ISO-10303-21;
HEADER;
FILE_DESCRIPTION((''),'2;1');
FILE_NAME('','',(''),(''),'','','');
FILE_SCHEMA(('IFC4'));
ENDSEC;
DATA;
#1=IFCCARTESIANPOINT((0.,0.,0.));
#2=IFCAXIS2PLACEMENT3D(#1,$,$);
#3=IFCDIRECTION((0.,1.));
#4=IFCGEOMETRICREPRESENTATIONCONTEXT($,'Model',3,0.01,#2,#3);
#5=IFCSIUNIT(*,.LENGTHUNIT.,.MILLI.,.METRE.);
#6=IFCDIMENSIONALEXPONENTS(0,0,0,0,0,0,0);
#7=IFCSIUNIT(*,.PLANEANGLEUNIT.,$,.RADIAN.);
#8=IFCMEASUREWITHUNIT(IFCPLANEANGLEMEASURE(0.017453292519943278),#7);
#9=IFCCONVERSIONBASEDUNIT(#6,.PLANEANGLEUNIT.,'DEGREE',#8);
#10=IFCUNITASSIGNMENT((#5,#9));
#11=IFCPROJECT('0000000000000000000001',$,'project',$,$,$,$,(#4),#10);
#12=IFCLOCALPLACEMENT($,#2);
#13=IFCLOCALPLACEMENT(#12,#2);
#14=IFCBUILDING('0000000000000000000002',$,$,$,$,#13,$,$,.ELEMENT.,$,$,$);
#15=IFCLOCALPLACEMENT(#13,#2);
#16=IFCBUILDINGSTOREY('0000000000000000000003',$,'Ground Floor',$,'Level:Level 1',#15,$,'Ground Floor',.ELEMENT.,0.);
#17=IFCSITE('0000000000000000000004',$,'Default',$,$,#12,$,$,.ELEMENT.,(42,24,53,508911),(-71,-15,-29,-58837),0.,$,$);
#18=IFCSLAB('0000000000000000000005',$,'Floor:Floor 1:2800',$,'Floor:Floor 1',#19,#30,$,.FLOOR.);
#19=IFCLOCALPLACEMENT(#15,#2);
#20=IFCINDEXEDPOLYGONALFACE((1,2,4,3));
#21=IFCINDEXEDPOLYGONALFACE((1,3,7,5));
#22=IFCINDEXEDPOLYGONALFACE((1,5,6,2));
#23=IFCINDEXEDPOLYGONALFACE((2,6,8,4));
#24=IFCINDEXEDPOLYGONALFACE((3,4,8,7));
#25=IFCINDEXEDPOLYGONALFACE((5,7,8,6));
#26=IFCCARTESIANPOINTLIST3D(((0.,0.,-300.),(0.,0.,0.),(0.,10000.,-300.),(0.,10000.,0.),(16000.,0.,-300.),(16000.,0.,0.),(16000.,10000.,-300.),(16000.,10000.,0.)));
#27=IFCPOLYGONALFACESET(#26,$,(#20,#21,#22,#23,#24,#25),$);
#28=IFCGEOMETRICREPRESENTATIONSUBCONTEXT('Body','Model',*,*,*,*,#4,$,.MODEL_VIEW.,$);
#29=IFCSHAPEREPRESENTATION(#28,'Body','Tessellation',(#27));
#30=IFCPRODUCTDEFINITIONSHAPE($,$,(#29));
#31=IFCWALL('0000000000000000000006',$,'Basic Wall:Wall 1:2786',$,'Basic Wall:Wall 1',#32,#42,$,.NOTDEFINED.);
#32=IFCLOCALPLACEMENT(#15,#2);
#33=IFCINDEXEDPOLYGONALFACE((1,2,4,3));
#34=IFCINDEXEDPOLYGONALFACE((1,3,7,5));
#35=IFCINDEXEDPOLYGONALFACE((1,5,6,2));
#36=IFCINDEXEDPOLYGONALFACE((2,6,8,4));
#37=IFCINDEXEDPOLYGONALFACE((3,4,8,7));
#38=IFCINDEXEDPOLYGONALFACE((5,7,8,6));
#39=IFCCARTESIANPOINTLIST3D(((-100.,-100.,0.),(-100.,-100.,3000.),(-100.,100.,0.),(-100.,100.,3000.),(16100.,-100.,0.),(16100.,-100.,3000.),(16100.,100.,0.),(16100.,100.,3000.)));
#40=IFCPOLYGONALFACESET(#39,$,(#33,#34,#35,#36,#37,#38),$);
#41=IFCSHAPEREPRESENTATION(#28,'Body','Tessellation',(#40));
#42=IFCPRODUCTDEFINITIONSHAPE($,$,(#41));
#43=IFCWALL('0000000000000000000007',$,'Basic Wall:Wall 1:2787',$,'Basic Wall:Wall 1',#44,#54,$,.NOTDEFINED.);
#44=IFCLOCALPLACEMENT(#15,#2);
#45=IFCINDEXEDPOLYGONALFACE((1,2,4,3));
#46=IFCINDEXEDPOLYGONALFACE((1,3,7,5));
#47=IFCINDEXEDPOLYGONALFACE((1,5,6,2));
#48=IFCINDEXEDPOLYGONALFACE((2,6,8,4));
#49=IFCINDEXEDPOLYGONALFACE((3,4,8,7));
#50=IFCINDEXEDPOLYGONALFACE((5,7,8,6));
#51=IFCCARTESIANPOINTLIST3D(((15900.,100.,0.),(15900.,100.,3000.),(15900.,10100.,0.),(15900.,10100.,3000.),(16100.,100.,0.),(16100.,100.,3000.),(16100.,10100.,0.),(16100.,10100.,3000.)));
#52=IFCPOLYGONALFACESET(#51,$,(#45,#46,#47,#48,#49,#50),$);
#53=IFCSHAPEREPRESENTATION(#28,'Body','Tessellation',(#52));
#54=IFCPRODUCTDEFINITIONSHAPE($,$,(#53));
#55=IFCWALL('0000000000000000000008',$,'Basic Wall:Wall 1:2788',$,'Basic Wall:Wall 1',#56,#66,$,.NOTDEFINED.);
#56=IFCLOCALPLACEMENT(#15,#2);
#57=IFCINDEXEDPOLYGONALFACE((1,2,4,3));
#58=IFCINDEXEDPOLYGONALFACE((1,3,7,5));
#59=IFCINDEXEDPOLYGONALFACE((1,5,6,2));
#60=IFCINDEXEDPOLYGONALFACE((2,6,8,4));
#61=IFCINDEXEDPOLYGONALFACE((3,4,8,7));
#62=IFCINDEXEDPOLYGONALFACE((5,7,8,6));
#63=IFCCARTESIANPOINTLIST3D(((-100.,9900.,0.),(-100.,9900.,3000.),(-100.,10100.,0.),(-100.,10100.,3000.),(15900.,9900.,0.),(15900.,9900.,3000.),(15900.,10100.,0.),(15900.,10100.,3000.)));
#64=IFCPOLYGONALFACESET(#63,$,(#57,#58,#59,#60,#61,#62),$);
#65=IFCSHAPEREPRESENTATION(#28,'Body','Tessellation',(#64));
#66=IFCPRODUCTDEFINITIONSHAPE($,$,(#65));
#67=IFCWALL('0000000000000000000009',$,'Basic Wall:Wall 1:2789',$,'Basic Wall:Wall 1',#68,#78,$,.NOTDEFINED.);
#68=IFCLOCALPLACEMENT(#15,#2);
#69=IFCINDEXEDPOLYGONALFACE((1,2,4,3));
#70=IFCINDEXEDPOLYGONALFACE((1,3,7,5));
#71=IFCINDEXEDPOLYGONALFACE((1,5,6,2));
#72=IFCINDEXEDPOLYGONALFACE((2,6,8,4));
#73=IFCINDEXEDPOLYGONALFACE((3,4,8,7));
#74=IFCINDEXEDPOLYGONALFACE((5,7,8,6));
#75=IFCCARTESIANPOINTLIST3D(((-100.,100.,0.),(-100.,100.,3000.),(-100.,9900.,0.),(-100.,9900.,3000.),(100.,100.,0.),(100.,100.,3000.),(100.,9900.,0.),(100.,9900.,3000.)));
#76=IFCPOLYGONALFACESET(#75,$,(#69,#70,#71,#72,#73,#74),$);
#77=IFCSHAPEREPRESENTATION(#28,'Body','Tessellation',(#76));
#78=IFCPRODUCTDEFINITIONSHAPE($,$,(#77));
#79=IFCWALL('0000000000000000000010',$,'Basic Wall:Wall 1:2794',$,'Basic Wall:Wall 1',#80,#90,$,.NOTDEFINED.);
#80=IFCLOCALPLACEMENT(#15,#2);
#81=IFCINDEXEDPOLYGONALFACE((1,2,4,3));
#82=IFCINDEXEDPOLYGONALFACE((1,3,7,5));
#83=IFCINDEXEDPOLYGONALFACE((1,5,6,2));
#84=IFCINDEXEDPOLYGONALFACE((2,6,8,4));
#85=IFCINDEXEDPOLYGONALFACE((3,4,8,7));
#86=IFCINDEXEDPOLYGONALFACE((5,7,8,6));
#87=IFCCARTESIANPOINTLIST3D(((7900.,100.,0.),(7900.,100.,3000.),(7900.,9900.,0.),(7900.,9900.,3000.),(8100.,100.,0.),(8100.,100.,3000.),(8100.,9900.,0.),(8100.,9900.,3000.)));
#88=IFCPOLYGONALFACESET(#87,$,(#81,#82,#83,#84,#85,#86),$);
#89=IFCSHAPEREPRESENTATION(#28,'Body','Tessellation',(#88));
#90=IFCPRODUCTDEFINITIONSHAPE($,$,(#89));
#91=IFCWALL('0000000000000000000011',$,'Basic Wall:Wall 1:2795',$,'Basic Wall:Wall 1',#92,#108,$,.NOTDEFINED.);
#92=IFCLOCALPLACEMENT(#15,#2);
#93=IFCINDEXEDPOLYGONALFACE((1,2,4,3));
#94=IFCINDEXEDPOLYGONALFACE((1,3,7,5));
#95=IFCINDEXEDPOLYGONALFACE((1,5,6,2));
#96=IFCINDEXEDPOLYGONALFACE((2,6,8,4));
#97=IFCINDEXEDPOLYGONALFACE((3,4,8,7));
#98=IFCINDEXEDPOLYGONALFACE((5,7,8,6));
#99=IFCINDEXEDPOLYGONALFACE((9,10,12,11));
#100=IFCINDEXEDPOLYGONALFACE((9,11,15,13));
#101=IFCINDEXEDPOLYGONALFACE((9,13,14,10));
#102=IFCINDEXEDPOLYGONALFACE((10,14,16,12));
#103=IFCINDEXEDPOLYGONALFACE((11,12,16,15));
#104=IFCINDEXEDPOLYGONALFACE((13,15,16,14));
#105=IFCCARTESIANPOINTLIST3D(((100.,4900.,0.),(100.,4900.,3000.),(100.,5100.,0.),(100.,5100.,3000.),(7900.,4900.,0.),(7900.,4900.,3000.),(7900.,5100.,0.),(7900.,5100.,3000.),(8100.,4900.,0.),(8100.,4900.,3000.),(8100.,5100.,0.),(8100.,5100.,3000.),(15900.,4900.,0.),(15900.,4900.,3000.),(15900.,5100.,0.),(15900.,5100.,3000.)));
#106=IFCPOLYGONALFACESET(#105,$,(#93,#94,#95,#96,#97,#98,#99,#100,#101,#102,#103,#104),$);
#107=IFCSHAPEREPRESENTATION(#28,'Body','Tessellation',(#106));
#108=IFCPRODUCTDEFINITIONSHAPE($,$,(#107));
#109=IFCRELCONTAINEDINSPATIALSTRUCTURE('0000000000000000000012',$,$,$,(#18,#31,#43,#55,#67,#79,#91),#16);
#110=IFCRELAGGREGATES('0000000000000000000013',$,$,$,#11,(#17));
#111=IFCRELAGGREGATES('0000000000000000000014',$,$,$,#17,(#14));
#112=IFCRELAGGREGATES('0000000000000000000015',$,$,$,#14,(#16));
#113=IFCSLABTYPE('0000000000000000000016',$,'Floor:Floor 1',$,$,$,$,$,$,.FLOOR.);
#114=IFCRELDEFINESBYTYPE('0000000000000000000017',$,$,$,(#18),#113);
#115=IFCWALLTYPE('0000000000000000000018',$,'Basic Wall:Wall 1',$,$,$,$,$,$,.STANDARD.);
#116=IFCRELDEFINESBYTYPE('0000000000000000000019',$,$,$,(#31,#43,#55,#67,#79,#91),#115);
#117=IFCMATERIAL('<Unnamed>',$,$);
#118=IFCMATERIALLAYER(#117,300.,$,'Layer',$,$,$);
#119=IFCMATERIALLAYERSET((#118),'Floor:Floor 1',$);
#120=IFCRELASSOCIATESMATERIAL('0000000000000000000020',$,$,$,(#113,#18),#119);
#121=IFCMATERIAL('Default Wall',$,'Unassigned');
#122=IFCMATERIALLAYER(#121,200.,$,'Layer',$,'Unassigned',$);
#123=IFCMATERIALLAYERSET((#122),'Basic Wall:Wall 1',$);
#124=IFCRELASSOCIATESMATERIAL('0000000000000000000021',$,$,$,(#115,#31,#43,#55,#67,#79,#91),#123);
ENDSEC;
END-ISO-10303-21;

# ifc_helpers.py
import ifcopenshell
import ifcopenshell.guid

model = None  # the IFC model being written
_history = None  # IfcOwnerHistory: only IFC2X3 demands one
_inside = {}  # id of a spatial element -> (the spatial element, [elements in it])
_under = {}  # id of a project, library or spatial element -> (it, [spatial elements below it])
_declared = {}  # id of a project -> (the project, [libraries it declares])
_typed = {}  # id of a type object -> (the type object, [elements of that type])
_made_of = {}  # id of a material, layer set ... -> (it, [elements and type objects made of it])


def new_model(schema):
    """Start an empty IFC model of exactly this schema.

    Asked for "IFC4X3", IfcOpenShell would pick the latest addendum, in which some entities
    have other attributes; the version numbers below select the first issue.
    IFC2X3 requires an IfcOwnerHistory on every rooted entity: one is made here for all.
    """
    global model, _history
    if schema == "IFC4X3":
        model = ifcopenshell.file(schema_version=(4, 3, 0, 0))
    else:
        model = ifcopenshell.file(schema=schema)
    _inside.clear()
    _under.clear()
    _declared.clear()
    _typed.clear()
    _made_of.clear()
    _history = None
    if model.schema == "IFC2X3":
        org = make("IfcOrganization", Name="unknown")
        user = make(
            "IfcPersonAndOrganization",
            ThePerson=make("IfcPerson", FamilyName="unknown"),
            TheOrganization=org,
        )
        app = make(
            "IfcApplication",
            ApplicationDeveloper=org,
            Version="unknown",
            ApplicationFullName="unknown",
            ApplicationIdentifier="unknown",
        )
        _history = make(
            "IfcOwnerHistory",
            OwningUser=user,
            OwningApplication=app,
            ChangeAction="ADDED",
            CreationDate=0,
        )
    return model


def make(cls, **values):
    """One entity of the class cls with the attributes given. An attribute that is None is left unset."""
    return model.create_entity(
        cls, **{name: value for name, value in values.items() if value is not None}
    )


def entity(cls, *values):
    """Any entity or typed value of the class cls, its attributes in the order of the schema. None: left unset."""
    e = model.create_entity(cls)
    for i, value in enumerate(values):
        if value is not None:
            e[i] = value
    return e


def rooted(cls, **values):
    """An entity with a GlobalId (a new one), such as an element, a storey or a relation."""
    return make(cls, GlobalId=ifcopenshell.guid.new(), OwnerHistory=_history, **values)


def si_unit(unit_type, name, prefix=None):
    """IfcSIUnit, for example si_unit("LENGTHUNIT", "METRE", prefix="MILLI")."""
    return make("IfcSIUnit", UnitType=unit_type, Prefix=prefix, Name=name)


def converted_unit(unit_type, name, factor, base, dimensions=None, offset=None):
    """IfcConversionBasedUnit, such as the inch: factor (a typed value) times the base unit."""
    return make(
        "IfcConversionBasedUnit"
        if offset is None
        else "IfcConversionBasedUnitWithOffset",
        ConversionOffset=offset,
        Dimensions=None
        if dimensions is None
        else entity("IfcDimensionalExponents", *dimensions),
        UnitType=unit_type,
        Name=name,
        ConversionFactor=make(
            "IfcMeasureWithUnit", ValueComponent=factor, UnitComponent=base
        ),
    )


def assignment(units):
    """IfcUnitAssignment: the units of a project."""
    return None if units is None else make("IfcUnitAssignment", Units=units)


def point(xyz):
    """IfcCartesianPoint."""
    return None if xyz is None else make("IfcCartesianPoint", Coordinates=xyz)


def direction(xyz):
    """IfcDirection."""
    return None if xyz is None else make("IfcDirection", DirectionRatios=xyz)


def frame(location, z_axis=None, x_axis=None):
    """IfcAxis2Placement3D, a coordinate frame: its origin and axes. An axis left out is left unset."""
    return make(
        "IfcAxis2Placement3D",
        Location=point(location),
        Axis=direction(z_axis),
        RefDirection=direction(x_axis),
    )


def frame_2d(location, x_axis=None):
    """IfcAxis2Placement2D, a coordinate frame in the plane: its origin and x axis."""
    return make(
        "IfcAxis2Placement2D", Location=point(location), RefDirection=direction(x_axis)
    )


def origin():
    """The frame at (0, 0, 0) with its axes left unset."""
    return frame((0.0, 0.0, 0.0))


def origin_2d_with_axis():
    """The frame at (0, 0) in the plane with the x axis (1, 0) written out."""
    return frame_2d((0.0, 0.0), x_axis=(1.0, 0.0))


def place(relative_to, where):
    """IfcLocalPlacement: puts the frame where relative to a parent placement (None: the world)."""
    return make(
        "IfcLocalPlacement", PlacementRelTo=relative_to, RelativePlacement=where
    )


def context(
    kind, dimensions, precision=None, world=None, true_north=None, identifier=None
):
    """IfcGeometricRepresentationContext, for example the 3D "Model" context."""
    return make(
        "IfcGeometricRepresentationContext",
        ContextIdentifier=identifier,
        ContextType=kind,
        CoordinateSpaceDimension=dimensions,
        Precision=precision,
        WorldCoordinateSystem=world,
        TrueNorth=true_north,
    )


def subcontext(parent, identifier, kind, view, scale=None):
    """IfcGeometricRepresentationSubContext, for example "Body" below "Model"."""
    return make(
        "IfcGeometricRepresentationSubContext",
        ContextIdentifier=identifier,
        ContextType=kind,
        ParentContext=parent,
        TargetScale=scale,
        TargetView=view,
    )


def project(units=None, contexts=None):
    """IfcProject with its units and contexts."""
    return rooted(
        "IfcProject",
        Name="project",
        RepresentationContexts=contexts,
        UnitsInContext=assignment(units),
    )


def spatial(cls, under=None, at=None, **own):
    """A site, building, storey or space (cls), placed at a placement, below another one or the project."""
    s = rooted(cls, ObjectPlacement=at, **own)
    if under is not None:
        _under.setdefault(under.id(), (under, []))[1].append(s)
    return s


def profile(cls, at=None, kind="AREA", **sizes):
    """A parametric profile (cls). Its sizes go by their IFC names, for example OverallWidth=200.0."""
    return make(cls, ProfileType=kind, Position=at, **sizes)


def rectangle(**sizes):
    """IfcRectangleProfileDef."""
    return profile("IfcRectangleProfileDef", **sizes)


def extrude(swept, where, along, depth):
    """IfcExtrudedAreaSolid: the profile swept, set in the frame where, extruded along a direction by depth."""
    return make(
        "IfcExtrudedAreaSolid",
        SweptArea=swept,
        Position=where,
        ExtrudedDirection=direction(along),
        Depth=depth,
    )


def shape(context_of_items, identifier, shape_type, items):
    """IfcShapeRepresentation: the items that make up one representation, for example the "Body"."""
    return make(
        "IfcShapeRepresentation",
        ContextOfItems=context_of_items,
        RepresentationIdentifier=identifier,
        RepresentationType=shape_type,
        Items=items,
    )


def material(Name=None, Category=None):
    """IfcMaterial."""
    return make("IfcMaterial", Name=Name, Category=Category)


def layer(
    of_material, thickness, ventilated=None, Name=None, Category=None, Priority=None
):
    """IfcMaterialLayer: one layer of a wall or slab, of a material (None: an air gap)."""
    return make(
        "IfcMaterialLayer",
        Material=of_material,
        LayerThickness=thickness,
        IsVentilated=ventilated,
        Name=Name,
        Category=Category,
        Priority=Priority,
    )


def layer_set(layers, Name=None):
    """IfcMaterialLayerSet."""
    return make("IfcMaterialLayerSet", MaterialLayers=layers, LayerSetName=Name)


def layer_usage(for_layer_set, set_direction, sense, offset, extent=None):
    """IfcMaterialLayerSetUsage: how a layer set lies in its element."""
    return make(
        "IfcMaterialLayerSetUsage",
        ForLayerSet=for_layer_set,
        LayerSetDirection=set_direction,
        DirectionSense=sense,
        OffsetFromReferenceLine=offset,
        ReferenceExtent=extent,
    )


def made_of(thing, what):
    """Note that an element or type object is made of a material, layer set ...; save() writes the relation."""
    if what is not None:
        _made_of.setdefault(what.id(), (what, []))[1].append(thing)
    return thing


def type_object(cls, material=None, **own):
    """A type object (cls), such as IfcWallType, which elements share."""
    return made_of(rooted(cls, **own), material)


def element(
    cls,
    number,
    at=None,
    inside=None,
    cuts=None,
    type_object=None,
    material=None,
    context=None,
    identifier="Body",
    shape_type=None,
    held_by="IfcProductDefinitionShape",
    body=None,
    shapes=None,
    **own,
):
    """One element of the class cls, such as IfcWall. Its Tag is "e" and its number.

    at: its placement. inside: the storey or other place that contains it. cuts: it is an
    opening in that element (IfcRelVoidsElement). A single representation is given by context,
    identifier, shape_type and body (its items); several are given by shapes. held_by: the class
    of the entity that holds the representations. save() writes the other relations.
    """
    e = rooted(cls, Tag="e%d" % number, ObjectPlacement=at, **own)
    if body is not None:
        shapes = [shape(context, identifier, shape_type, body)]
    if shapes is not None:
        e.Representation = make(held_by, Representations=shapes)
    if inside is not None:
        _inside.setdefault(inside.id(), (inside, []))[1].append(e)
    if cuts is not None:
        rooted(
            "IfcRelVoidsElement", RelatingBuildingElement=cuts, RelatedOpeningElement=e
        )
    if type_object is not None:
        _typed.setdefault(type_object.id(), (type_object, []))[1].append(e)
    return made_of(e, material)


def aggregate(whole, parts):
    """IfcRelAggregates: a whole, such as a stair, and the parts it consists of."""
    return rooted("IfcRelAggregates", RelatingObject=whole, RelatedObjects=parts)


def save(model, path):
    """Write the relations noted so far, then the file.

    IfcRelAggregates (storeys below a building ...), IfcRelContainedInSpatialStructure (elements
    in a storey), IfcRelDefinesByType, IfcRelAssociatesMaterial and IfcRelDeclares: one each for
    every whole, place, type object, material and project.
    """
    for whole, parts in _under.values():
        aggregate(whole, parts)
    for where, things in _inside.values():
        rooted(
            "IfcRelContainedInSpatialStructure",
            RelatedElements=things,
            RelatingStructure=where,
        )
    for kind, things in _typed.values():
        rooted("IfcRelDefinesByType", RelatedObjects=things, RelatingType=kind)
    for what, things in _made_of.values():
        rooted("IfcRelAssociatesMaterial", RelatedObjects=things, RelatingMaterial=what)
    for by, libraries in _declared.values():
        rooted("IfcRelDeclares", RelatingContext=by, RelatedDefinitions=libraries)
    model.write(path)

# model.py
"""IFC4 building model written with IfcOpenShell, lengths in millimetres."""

from ifc_helpers import new_model, entity, si_unit, converted_unit, direction, frame, frame_2d, origin, origin_2d_with_axis, place, context, subcontext, project, spatial, rectangle, extrude, material, layer, layer_set, layer_usage, type_object, element, save


model = new_model("IFC4")

# Units and contexts
model_context = context("Model", 3, precision=0.01, world=origin(), true_north=direction((0.0, 1.0)))
body_context = subcontext(model_context, "Body", "Model", "MODEL_VIEW")
ifc_project = project(units=[si_unit("LENGTHUNIT", "METRE", prefix="MILLI"), converted_unit("PLANEANGLEUNIT", "DEGREE", entity("IfcPlaneAngleMeasure", 0.017453292519943278), si_unit("PLANEANGLEUNIT", "RADIAN"), dimensions=[0, 0, 0, 0, 0, 0, 0])], contexts=[model_context])

# Site, building, storey
site_placement = place(None, origin())
site = spatial("IfcSite", under=ifc_project, at=site_placement, Name="Default", CompositionType="ELEMENT", RefLatitude=(42, 24, 53, 508911), RefLongitude=(-71, -15, -29, -58837), RefElevation=0.0)
building_placement = place(site_placement, origin())
building = spatial("IfcBuilding", under=site, at=building_placement, CompositionType="ELEMENT")
storey_placement = place(building_placement, origin())
storey = spatial("IfcBuildingStorey", under=building, at=storey_placement, Name="Ground Floor", ObjectType="Level:Level 1", LongName="Ground Floor", CompositionType="ELEMENT", Elevation=0.0)

# Slab
ifc_material_1 = material(Name="<Unnamed>")
ifc_layer_1 = layer(ifc_material_1, 300.0, Name="Layer")
ifc_layer_set_1 = layer_set([ifc_layer_1], Name="Floor:Floor 1")
ifc_layer_usage_1 = layer_usage(ifc_layer_set_1, "AXIS3", "POSITIVE", 0.0)
slab_type = type_object("IfcSlabType", Name="Floor:Floor 1", PredefinedType="FLOOR", material=ifc_layer_set_1)
slab_placement = place(storey_placement, origin())
element("IfcSlab", 1, at=slab_placement, inside=storey, type_object=slab_type, material=ifc_layer_usage_1, Name="Floor:Floor 1:2800", ObjectType="Floor:Floor 1", PredefinedType="FLOOR", context=body_context, shape_type="SweptSolid", body=[
    extrude(rectangle(XDim=10000.0, YDim=16000.0, at=origin_2d_with_axis()), frame((8000.0, 5000.0, 0.0), z_axis=(0.0, 0.0, -1.0), x_axis=(0.0, 1.0, 0.0)), (0.0, 0.0, 1.0), 300.0),
])

# Walls
ifc_material_2 = material(Name="Default Wall", Category="Unassigned")
ifc_layer_2 = layer(ifc_material_2, 200.0, Name="Layer", Category="Unassigned")
ifc_layer_set_2 = layer_set([ifc_layer_2], Name="Basic Wall:Wall 1")
ifc_layer_usage_2 = layer_usage(ifc_layer_set_2, "AXIS2", "NEGATIVE", 100.0)
wall_type = type_object("IfcWallType", Name="Basic Wall:Wall 1", PredefinedType="STANDARD", material=ifc_layer_set_2)
wall_1_placement = place(storey_placement, frame((-100.0, 0.0, 0.0)))
element("IfcWall", 2, at=wall_1_placement, inside=storey, type_object=wall_type, material=ifc_layer_usage_2, Name="Basic Wall:Wall 1:2786", ObjectType="Basic Wall:Wall 1", PredefinedType="NOTDEFINED", context=body_context, shape_type="SweptSolid", body=[
    extrude(rectangle(XDim=16200.0, YDim=200.0, at=frame_2d((8100.0, 0.0), x_axis=(-1.0, 0.0))), origin(), (0.0, 0.0, 1.0), 3000.0),
])
ifc_layer_usage_3 = layer_usage(ifc_layer_set_2, "AXIS2", "NEGATIVE", 100.0)
wall_2_placement = place(storey_placement, frame((16000.0, 100.0, 0.0), z_axis=(0.0, 0.0, 1.0), x_axis=(0.0, 1.0, 0.0)))
element("IfcWall", 3, at=wall_2_placement, inside=storey, type_object=wall_type, material=ifc_layer_usage_3, Name="Basic Wall:Wall 1:2787", ObjectType="Basic Wall:Wall 1", PredefinedType="NOTDEFINED", context=body_context, shape_type="SweptSolid", body=[
    extrude(rectangle(XDim=10000.0, YDim=200.0, at=frame_2d((5000.0, 0.0), x_axis=(-1.0, 0.0))), origin(), (0.0, 0.0, 1.0), 3000.0),
])
ifc_layer_usage_4 = layer_usage(ifc_layer_set_2, "AXIS2", "NEGATIVE", 100.0)
wall_3_placement = place(storey_placement, frame((15900.0, 10000.0, 0.0), z_axis=(0.0, 0.0, 1.0), x_axis=(-1.0, 0.0, 0.0)))
element("IfcWall", 4, at=wall_3_placement, inside=storey, type_object=wall_type, material=ifc_layer_usage_4, Name="Basic Wall:Wall 1:2788", ObjectType="Basic Wall:Wall 1", PredefinedType="NOTDEFINED", context=body_context, shape_type="SweptSolid", body=[
    extrude(rectangle(XDim=16000.0, YDim=200.0, at=frame_2d((8000.0, 0.0), x_axis=(-1.0, 0.0))), origin(), (0.0, 0.0, 1.0), 3000.0),
])
ifc_layer_usage_5 = layer_usage(ifc_layer_set_2, "AXIS2", "NEGATIVE", 100.0)
wall_4_placement = place(storey_placement, frame((0.0, 9900.0, 0.0), z_axis=(0.0, 0.0, 1.0), x_axis=(0.0, -1.0, 0.0)))
element("IfcWall", 5, at=wall_4_placement, inside=storey, type_object=wall_type, material=ifc_layer_usage_5, Name="Basic Wall:Wall 1:2789", ObjectType="Basic Wall:Wall 1", PredefinedType="NOTDEFINED", context=body_context, shape_type="SweptSolid", body=[
    extrude(rectangle(XDim=9800.0, YDim=200.0, at=frame_2d((4900.0, 0.0), x_axis=(-1.0, 0.0))), origin(), (0.0, 0.0, 1.0), 3000.0),
])
ifc_layer_usage_6 = layer_usage(ifc_layer_set_2, "AXIS2", "NEGATIVE", 100.0)
wall_5_placement = place(storey_placement, frame((8000.0, 100.0, 0.0), z_axis=(0.0, 0.0, 1.0), x_axis=(0.0, 1.0, 0.0)))
element("IfcWall", 6, at=wall_5_placement, inside=storey, type_object=wall_type, material=ifc_layer_usage_6, Name="Basic Wall:Wall 1:2794", ObjectType="Basic Wall:Wall 1", PredefinedType="NOTDEFINED", context=body_context, shape_type="SweptSolid", body=[
    extrude(rectangle(XDim=9800.0, YDim=200.0, at=frame_2d((4900.0, 0.0), x_axis=(-1.0, 0.0))), origin(), (0.0, 0.0, 1.0), 3000.0),
])

# Wall, opening
ifc_layer_usage_7 = layer_usage(ifc_layer_set_2, "AXIS2", "NEGATIVE", 100.0)
wall_6_placement = place(storey_placement, frame((100.0, 5000.0, 0.0)))
wall_6 = element("IfcWall", 7, at=wall_6_placement, inside=storey, type_object=wall_type, material=ifc_layer_usage_7, Name="Basic Wall:Wall 1:2795", ObjectType="Basic Wall:Wall 1", PredefinedType="NOTDEFINED", context=body_context, shape_type="SweptSolid", body=[
    extrude(rectangle(XDim=15800.0, YDim=200.0, at=frame_2d((7900.0, 0.0), x_axis=(-1.0, 0.0))), origin(), (0.0, 0.0, 1.0), 3000.0),
])
opening_placement = place(storey_placement, frame((100.0, 5000.0, 0.0)))
element("IfcOpeningElement", 8, at=opening_placement, cuts=wall_6, PredefinedType="OPENING", context=body_context, shape_type="SweptSolid", body=[
    extrude(rectangle(XDim=3000.0, YDim=200.0, at=origin_2d_with_axis()), frame((7800.0, 0.0, 1500.0), z_axis=(1.0, 0.0, 0.0), x_axis=(0.0, 0.0, -1.0)), (0.0, 0.0, 1.0), 200.0),
])

save(model, "model.ifc")
